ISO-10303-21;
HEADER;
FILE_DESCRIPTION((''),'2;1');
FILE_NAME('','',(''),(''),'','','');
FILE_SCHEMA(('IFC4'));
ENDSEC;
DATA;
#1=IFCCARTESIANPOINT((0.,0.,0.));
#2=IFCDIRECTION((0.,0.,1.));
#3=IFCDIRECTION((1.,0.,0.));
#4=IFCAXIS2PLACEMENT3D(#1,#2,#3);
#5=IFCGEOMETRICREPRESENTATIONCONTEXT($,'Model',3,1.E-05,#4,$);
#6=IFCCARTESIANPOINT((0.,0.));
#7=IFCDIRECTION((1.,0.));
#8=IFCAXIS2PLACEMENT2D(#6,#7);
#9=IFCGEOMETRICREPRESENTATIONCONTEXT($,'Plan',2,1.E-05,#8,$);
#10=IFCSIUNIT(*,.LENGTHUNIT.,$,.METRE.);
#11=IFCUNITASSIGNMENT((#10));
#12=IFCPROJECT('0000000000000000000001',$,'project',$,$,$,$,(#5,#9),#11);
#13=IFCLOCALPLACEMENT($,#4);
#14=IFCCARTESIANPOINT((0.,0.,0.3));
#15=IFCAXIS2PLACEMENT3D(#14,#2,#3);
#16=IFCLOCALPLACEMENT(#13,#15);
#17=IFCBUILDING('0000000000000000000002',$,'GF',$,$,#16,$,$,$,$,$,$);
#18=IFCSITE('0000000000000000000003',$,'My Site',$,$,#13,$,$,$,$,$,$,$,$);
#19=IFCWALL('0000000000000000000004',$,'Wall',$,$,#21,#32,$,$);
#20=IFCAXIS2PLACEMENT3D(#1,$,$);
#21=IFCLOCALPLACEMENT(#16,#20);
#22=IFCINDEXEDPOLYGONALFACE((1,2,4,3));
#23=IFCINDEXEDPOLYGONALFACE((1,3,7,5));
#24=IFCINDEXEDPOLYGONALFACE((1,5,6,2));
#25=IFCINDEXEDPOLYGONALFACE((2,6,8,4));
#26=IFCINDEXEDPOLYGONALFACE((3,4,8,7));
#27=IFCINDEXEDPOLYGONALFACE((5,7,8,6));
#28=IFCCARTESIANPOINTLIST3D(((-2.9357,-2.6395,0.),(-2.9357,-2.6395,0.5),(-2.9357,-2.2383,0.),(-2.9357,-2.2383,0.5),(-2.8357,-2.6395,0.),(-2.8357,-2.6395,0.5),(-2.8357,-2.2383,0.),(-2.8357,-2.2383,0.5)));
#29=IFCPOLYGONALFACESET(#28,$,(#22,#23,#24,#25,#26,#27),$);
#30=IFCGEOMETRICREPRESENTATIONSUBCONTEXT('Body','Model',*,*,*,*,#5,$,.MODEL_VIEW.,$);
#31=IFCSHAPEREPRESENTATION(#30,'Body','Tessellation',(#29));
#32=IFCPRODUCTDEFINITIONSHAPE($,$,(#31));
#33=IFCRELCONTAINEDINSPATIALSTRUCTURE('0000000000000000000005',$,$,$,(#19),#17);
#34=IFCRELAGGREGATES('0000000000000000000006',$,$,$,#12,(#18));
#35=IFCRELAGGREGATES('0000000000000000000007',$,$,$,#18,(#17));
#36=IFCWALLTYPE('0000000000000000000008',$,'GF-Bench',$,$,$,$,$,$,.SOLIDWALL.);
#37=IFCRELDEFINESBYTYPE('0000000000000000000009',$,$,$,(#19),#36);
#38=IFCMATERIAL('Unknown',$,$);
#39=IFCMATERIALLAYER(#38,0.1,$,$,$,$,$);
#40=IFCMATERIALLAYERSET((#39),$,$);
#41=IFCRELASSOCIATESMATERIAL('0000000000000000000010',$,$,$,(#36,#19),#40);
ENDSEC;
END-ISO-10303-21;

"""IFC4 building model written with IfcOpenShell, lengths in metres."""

from ifc_helpers import new_model, si_unit, frame, origin_with_axes, origin_2d_with_axis, place, context, subcontext, project, spatial, line, indexed_curve, outline, extrude, material, layer, layer_set, layer_usage, type_object, element, save


model = new_model("IFC4")

# Units and contexts
model_context = context("Model", 3, precision=1e-05, world=origin_with_axes())
plan_context = context("Plan", 2, precision=1e-05, world=origin_2d_with_axis())
body_context_1 = subcontext(model_context, "Body", "Model", "MODEL_VIEW")
ifc_project = project(units=[si_unit("LENGTHUNIT", "METRE")], contexts=[model_context, plan_context])

# Site, building
site_placement = place(None, origin_with_axes())
site = spatial("IfcSite", under=ifc_project, at=site_placement, Name="My Site")
building_placement = place(site_placement, frame((0.0, 0.0, 0.3), z_axis=(0.0, 0.0, 1.0), x_axis=(1.0, 0.0, 0.0)))
building = spatial("IfcBuilding", under=site, at=building_placement, Name="GF")

# Shared definitions
ifc_material = material(Name="Unknown")

# Wall
ifc_layer_1 = layer(ifc_material, 0.1)
ifc_layer_set_1 = layer_set([ifc_layer_1])
wall_type_1 = type_object("IfcWallType", Name="GF-Bench", PredefinedType="SOLIDWALL", material=ifc_layer_set_1)
ifc_layer_usage_1 = layer_usage(ifc_layer_set_1, "AXIS2", "POSITIVE", 0.0)
wall_1_placement = place(building_placement, frame((-2.9357, -2.2383, 0.0), z_axis=(0.0, 0.0, 1.0), x_axis=(-0.000002, -1.0, 0.0)))
element("IfcWall", 1, at=wall_1_placement, inside=building, type_object=wall_type_1, material=ifc_layer_usage_1, Name="Wall", context=body_context_1, shape_type="SweptSolid", body=[
    extrude(outline(indexed_curve([(0.0, 0.0), (0.0, 0.1), (0.4011, 0.1), (0.4011, 0.0)], segments=[line(1, 2, 3, 4, 1)])), origin_with_axes(), (0.0, 0.0, 1.0), 0.5),
])

save(model, "model.ifc")
